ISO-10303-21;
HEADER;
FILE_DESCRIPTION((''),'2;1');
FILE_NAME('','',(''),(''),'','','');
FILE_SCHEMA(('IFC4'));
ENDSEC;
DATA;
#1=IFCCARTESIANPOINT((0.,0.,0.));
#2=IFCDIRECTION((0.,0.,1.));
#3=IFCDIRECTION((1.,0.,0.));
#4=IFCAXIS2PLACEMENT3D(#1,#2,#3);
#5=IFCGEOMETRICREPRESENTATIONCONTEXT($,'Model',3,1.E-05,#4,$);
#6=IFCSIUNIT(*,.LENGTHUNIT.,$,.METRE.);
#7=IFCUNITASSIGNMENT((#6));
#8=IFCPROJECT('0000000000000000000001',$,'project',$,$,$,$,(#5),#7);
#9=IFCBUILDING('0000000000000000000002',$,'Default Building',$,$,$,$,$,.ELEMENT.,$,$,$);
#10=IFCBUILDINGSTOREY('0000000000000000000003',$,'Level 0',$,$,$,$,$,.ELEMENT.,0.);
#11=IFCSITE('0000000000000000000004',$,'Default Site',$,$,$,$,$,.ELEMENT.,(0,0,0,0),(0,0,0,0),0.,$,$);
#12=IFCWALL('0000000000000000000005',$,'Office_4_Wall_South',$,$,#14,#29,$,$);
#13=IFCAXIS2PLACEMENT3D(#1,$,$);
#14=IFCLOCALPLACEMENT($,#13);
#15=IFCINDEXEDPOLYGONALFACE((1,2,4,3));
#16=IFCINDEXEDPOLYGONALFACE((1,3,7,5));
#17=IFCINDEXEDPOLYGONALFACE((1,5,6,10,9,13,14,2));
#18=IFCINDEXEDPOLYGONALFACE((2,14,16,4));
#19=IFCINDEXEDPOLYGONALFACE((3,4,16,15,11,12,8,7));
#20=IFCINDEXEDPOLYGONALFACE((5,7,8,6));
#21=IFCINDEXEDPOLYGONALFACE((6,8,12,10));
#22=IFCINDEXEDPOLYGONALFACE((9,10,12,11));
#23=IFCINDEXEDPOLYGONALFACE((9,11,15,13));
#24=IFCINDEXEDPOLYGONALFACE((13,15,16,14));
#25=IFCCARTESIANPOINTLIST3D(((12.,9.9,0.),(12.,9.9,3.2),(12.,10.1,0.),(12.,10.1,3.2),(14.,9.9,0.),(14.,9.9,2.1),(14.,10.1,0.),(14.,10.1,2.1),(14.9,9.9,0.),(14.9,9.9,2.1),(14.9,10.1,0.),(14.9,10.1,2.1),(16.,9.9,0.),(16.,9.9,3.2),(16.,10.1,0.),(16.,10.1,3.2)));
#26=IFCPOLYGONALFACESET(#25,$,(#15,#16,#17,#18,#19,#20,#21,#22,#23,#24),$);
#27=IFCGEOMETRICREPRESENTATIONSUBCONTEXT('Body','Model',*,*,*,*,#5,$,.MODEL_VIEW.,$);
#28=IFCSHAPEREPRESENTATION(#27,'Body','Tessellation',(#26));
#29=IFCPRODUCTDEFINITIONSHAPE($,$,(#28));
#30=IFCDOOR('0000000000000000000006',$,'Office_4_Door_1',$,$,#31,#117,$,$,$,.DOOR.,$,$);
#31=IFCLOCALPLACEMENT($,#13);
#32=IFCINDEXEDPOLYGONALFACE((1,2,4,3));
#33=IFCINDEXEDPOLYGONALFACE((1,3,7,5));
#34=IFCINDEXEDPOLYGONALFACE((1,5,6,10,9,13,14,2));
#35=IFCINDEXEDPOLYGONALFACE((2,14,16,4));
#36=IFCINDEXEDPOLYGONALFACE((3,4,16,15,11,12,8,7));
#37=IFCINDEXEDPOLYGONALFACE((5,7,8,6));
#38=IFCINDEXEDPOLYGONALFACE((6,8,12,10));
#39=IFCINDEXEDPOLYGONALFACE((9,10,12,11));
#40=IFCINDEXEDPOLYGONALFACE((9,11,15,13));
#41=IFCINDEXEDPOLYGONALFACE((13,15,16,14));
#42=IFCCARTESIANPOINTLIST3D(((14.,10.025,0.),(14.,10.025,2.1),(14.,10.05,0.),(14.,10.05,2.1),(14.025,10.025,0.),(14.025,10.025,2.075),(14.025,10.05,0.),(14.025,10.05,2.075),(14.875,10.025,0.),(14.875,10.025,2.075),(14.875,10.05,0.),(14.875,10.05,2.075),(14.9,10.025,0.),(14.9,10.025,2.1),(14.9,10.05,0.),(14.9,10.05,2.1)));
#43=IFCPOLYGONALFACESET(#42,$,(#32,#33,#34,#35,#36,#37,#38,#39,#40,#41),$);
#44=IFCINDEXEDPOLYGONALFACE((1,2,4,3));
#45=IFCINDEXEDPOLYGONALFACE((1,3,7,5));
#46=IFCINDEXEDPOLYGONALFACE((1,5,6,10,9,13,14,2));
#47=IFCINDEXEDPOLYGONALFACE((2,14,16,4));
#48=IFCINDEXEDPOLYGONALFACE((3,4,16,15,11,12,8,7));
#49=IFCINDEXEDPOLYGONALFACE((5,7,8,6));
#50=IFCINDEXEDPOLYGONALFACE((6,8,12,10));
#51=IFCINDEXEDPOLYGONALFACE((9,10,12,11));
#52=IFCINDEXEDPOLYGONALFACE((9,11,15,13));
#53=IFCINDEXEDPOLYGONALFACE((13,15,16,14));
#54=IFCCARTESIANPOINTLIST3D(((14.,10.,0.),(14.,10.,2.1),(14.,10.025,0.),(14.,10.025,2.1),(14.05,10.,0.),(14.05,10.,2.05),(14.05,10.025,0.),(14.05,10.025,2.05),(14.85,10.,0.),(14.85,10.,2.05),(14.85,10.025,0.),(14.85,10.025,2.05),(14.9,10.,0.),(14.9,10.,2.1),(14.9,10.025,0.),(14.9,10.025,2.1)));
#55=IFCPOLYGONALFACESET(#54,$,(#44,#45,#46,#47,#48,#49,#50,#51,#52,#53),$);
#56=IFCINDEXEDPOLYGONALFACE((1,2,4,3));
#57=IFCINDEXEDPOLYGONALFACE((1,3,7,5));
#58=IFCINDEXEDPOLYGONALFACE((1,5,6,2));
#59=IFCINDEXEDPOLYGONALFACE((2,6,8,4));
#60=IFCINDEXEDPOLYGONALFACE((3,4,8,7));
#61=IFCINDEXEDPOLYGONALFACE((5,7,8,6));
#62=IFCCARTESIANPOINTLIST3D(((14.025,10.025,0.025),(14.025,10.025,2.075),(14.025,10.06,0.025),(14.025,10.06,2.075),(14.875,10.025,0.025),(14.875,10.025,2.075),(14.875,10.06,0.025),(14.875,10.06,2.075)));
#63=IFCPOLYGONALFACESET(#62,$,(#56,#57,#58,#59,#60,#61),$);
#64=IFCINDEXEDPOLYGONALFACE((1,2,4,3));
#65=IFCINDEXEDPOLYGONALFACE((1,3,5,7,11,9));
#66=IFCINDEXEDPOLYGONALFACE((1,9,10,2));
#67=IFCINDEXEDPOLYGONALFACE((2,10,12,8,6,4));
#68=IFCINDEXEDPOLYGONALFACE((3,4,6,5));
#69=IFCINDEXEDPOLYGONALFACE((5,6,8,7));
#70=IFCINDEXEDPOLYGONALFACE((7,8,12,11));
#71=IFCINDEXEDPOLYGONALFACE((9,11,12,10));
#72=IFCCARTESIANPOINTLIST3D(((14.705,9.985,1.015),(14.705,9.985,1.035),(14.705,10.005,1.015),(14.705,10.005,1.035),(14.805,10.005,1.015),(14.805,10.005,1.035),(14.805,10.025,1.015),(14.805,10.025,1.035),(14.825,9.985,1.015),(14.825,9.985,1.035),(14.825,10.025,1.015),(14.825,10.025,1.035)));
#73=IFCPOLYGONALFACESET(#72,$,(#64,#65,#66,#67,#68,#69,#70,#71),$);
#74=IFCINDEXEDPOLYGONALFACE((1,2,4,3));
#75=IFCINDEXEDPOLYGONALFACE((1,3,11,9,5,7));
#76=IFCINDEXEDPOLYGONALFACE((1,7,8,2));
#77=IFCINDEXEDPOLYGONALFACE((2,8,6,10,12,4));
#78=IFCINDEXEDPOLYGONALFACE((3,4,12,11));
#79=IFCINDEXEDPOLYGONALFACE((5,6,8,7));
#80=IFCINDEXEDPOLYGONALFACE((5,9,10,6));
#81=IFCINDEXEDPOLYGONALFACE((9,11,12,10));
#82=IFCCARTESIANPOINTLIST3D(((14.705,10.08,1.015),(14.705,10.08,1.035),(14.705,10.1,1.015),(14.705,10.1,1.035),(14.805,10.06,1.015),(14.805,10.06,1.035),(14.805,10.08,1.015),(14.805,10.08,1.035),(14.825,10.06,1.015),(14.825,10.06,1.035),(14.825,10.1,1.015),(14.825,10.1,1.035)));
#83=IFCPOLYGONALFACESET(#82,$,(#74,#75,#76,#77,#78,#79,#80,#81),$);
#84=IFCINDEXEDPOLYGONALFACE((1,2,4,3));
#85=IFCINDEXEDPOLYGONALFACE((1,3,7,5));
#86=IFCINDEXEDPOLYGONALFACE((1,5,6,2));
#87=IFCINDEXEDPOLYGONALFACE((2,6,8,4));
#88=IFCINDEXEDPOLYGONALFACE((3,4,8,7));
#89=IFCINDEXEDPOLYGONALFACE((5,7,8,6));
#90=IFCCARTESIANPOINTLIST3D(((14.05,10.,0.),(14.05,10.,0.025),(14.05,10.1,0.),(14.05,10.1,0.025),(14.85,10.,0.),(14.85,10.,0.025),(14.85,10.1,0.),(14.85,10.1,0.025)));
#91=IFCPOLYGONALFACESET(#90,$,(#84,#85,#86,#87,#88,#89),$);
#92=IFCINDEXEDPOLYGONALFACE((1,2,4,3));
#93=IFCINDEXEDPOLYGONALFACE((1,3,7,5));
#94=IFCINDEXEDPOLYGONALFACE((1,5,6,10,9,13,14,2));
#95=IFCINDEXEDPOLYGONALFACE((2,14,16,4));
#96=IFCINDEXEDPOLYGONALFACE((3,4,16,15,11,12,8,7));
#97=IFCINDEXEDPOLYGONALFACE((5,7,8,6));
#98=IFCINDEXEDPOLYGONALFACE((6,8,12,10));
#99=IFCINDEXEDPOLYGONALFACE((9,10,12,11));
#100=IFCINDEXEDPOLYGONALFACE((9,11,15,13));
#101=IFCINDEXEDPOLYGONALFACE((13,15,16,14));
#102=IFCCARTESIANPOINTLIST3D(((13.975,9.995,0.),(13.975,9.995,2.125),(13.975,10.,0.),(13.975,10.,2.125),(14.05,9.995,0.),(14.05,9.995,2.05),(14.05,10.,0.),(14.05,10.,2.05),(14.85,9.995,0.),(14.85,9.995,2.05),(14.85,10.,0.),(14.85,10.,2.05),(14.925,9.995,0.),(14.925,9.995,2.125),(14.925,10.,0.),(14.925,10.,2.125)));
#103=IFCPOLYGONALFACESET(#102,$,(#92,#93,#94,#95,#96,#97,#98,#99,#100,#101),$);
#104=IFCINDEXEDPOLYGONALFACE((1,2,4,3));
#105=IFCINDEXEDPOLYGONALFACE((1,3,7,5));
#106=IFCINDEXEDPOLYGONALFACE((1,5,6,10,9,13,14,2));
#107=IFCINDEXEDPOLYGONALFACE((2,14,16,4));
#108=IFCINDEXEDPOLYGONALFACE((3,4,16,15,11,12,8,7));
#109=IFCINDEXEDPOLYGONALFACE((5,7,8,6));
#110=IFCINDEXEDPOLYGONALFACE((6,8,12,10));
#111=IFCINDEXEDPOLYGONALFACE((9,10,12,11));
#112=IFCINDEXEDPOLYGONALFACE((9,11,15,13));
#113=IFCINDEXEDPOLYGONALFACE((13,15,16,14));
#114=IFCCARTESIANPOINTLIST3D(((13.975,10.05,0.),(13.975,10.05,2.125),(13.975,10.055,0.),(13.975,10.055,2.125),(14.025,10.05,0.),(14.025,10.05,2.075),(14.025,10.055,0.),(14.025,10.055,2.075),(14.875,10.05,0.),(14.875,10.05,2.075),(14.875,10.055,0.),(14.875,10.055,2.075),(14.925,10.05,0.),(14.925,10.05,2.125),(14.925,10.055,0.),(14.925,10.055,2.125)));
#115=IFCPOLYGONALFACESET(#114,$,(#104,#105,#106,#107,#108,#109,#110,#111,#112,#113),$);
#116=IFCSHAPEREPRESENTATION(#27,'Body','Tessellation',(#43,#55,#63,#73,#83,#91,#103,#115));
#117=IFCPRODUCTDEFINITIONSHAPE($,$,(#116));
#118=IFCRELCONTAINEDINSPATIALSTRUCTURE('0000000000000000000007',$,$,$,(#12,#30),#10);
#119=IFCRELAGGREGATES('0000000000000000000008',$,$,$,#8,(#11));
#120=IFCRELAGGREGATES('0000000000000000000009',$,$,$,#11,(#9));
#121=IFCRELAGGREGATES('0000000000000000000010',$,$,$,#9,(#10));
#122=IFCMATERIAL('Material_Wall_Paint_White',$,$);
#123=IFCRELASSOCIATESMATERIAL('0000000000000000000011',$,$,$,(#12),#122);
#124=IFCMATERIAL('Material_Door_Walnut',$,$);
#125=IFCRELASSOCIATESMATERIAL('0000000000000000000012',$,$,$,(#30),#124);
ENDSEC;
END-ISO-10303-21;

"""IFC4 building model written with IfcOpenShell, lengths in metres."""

from ifc_helpers import new_model, si_unit, frame, origin_with_axes, place, context, subcontext, project, spatial, line, indexed_curve, outline, extrude, material, element, fill, save


model = new_model("IFC4")

# Units and contexts
model_context = context("Model", 3, precision=1e-05, world=origin_with_axes())
body_context = subcontext(model_context, "Body", "Model", "MODEL_VIEW")
ifc_project = project(units=[si_unit("LENGTHUNIT", "METRE")], contexts=[model_context])

# Site, building, storey
site = spatial("IfcSite", under=ifc_project, Name="Default Site", CompositionType="ELEMENT", RefLatitude=(0, 0, 0, 0), RefLongitude=(0, 0, 0, 0), RefElevation=0.0)
building = spatial("IfcBuilding", under=site, Name="Default Building", CompositionType="ELEMENT")
storey = spatial("IfcBuildingStorey", under=building, Name="Level 0", CompositionType="ELEMENT", Elevation=0.0)

# Shared definitions
ifc_material_1 = material(Name="Material_Wall_Paint_White")

# Shared definitions
ifc_material_2 = material(Name="Material_Door_Walnut")

# Wall, opening, door
wall_1_placement = place(None, frame((12.0, 10.0, 0.0), z_axis=(0.0, 0.0, 1.0), x_axis=(1.0, 0.0, 0.0)))
wall_1 = element("IfcWall", 1, at=wall_1_placement, inside=storey, material=ifc_material_1, Name="Office_4_Wall_South", context=body_context, shape_type="SweptSolid", body=[
    extrude(outline(indexed_curve([(0.0, 0.0), (0.0, 0.2), (4.0, 0.2), (4.0, 0.0), (0.0, 0.0)], self_intersect=False)), frame((0.0, -0.1, 0.0), z_axis=(0.0, 0.0, 1.0), x_axis=(1.0, 0.0, 0.0)), (0.0, 0.0, 1.0), 3.2),
])
opening_1_placement = place(wall_1_placement, frame((2.0, -0.5, 0.0), z_axis=(0.0, 0.0, 1.0), x_axis=(1.0, 0.0, 0.0)))
opening_1 = element("IfcOpeningElement", 2, at=opening_1_placement, inside=storey, cuts=wall_1, PredefinedType="OPENING", context=body_context, shape_type="SweptSolid", body=[
    extrude(outline(indexed_curve([(0.0, 0.0), (0.0, 1.0), (0.9, 1.0), (0.9, 0.0), (0.0, 0.0)], self_intersect=False)), origin_with_axes(), (0.0, 0.0, 1.0), 2.1),
])
door_1_placement = place(None, frame((14.0, 10.0, 0.0), z_axis=(0.0, 0.0, 1.0), x_axis=(1.0, 0.0, 0.0)))
door_1 = element("IfcDoor", 3, at=door_1_placement, inside=storey, material=ifc_material_2, Name="Office_4_Door_1", PredefinedType="DOOR", context=body_context, shape_type="SweptSolid", body=[
    extrude(outline(indexed_curve([(0.0, 0.0), (0.0, 2.1), (0.9, 2.1), (0.9, 0.0), (0.875, 0.0), (0.875, 2.075), (0.025, 2.075), (0.025, 0.0)], segments=[line(1, 2, 3, 4, 5, 6, 7, 8, 1)])), frame((0.0, 0.025, 0.0), z_axis=(0.0, -1.0, 0.0), x_axis=(1.0, 0.0, 0.0)), (0.0, 0.0, -1.0), 0.025),
    extrude(outline(indexed_curve([(0.0, 0.0), (0.0, 2.1), (0.9, 2.1), (0.9, 0.0), (0.85, 0.0), (0.85, 2.05), (0.05, 2.05), (0.05, 0.0)], segments=[line(1, 2, 3, 4, 5, 6, 7, 8, 1)])), frame((0.0, 0.0, 0.0), z_axis=(0.0, -1.0, 0.0), x_axis=(1.0, 0.0, 0.0)), (0.0, 0.0, -1.0), 0.025),
    extrude(outline(indexed_curve([(0.0, 0.0), (0.85, 0.0), (0.85, 0.035), (0.0, 0.035)], segments=[line(1, 2, 3, 4, 1)])), frame((0.025, 0.025, 0.025), z_axis=(0.0, 0.0, 1.0), x_axis=(1.0, 0.0, 0.0)), (0.0, 0.0, 1.0), 2.05),
    extrude(outline(indexed_curve([(0.0, 0.0), (0.0, -0.04), (-0.12, -0.04), (-0.12, -0.02), (-0.02, -0.02), (-0.02, 0.0)], segments=[line(1, 2, 3, 4, 5, 6, 1)])), frame((0.825, 0.025, 1.015), z_axis=(0.0, 0.0, 1.0), x_axis=(1.0, 0.0, 0.0)), (0.0, 0.0, 1.0), 0.02),
    extrude(outline(indexed_curve([(0.0, 0.0), (0.0, 0.04), (-0.12, 0.04), (-0.12, 0.02), (-0.02, 0.02), (-0.02, 0.0)], segments=[line(1, 2, 3, 4, 5, 6, 1)])), frame((0.825, 0.06, 1.015), z_axis=(0.0, 0.0, 1.0), x_axis=(1.0, 0.0, 0.0)), (0.0, 0.0, 1.0), 0.02),
    extrude(outline(indexed_curve([(0.0, 0.0), (0.8, 0.0), (0.8, 0.1), (0.0, 0.1)], segments=[line(1, 2, 3, 4, 1)])), frame((0.05, 0.0, 0.0), z_axis=(0.0, 0.0, 1.0), x_axis=(1.0, 0.0, 0.0)), (0.0, 0.0, 1.0), 0.025),
    extrude(outline(indexed_curve([(0.0, 0.0), (0.0, 2.125), (0.95, 2.125), (0.95, 0.0), (0.875, 0.0), (0.875, 2.05), (0.075, 2.05), (0.075, 0.0)], segments=[line(1, 2, 3, 4, 5, 6, 7, 8, 1)])), frame((-0.025, -0.005, 0.0), z_axis=(0.0, -1.0, 0.0), x_axis=(1.0, 0.0, 0.0)), (0.0, 0.0, -1.0), 0.005),
    extrude(outline(indexed_curve([(0.0, 0.0), (0.0, 2.125), (0.95, 2.125), (0.95, 0.0), (0.9, 0.0), (0.9, 2.075), (0.05, 2.075), (0.05, 0.0)], segments=[line(1, 2, 3, 4, 5, 6, 7, 8, 1)])), frame((-0.025, 0.05, 0.0), z_axis=(0.0, -1.0, 0.0), x_axis=(1.0, 0.0, 0.0)), (0.0, 0.0, -1.0), 0.005),
])
fill(opening_1, door_1)

save(model, "model.ifc")
